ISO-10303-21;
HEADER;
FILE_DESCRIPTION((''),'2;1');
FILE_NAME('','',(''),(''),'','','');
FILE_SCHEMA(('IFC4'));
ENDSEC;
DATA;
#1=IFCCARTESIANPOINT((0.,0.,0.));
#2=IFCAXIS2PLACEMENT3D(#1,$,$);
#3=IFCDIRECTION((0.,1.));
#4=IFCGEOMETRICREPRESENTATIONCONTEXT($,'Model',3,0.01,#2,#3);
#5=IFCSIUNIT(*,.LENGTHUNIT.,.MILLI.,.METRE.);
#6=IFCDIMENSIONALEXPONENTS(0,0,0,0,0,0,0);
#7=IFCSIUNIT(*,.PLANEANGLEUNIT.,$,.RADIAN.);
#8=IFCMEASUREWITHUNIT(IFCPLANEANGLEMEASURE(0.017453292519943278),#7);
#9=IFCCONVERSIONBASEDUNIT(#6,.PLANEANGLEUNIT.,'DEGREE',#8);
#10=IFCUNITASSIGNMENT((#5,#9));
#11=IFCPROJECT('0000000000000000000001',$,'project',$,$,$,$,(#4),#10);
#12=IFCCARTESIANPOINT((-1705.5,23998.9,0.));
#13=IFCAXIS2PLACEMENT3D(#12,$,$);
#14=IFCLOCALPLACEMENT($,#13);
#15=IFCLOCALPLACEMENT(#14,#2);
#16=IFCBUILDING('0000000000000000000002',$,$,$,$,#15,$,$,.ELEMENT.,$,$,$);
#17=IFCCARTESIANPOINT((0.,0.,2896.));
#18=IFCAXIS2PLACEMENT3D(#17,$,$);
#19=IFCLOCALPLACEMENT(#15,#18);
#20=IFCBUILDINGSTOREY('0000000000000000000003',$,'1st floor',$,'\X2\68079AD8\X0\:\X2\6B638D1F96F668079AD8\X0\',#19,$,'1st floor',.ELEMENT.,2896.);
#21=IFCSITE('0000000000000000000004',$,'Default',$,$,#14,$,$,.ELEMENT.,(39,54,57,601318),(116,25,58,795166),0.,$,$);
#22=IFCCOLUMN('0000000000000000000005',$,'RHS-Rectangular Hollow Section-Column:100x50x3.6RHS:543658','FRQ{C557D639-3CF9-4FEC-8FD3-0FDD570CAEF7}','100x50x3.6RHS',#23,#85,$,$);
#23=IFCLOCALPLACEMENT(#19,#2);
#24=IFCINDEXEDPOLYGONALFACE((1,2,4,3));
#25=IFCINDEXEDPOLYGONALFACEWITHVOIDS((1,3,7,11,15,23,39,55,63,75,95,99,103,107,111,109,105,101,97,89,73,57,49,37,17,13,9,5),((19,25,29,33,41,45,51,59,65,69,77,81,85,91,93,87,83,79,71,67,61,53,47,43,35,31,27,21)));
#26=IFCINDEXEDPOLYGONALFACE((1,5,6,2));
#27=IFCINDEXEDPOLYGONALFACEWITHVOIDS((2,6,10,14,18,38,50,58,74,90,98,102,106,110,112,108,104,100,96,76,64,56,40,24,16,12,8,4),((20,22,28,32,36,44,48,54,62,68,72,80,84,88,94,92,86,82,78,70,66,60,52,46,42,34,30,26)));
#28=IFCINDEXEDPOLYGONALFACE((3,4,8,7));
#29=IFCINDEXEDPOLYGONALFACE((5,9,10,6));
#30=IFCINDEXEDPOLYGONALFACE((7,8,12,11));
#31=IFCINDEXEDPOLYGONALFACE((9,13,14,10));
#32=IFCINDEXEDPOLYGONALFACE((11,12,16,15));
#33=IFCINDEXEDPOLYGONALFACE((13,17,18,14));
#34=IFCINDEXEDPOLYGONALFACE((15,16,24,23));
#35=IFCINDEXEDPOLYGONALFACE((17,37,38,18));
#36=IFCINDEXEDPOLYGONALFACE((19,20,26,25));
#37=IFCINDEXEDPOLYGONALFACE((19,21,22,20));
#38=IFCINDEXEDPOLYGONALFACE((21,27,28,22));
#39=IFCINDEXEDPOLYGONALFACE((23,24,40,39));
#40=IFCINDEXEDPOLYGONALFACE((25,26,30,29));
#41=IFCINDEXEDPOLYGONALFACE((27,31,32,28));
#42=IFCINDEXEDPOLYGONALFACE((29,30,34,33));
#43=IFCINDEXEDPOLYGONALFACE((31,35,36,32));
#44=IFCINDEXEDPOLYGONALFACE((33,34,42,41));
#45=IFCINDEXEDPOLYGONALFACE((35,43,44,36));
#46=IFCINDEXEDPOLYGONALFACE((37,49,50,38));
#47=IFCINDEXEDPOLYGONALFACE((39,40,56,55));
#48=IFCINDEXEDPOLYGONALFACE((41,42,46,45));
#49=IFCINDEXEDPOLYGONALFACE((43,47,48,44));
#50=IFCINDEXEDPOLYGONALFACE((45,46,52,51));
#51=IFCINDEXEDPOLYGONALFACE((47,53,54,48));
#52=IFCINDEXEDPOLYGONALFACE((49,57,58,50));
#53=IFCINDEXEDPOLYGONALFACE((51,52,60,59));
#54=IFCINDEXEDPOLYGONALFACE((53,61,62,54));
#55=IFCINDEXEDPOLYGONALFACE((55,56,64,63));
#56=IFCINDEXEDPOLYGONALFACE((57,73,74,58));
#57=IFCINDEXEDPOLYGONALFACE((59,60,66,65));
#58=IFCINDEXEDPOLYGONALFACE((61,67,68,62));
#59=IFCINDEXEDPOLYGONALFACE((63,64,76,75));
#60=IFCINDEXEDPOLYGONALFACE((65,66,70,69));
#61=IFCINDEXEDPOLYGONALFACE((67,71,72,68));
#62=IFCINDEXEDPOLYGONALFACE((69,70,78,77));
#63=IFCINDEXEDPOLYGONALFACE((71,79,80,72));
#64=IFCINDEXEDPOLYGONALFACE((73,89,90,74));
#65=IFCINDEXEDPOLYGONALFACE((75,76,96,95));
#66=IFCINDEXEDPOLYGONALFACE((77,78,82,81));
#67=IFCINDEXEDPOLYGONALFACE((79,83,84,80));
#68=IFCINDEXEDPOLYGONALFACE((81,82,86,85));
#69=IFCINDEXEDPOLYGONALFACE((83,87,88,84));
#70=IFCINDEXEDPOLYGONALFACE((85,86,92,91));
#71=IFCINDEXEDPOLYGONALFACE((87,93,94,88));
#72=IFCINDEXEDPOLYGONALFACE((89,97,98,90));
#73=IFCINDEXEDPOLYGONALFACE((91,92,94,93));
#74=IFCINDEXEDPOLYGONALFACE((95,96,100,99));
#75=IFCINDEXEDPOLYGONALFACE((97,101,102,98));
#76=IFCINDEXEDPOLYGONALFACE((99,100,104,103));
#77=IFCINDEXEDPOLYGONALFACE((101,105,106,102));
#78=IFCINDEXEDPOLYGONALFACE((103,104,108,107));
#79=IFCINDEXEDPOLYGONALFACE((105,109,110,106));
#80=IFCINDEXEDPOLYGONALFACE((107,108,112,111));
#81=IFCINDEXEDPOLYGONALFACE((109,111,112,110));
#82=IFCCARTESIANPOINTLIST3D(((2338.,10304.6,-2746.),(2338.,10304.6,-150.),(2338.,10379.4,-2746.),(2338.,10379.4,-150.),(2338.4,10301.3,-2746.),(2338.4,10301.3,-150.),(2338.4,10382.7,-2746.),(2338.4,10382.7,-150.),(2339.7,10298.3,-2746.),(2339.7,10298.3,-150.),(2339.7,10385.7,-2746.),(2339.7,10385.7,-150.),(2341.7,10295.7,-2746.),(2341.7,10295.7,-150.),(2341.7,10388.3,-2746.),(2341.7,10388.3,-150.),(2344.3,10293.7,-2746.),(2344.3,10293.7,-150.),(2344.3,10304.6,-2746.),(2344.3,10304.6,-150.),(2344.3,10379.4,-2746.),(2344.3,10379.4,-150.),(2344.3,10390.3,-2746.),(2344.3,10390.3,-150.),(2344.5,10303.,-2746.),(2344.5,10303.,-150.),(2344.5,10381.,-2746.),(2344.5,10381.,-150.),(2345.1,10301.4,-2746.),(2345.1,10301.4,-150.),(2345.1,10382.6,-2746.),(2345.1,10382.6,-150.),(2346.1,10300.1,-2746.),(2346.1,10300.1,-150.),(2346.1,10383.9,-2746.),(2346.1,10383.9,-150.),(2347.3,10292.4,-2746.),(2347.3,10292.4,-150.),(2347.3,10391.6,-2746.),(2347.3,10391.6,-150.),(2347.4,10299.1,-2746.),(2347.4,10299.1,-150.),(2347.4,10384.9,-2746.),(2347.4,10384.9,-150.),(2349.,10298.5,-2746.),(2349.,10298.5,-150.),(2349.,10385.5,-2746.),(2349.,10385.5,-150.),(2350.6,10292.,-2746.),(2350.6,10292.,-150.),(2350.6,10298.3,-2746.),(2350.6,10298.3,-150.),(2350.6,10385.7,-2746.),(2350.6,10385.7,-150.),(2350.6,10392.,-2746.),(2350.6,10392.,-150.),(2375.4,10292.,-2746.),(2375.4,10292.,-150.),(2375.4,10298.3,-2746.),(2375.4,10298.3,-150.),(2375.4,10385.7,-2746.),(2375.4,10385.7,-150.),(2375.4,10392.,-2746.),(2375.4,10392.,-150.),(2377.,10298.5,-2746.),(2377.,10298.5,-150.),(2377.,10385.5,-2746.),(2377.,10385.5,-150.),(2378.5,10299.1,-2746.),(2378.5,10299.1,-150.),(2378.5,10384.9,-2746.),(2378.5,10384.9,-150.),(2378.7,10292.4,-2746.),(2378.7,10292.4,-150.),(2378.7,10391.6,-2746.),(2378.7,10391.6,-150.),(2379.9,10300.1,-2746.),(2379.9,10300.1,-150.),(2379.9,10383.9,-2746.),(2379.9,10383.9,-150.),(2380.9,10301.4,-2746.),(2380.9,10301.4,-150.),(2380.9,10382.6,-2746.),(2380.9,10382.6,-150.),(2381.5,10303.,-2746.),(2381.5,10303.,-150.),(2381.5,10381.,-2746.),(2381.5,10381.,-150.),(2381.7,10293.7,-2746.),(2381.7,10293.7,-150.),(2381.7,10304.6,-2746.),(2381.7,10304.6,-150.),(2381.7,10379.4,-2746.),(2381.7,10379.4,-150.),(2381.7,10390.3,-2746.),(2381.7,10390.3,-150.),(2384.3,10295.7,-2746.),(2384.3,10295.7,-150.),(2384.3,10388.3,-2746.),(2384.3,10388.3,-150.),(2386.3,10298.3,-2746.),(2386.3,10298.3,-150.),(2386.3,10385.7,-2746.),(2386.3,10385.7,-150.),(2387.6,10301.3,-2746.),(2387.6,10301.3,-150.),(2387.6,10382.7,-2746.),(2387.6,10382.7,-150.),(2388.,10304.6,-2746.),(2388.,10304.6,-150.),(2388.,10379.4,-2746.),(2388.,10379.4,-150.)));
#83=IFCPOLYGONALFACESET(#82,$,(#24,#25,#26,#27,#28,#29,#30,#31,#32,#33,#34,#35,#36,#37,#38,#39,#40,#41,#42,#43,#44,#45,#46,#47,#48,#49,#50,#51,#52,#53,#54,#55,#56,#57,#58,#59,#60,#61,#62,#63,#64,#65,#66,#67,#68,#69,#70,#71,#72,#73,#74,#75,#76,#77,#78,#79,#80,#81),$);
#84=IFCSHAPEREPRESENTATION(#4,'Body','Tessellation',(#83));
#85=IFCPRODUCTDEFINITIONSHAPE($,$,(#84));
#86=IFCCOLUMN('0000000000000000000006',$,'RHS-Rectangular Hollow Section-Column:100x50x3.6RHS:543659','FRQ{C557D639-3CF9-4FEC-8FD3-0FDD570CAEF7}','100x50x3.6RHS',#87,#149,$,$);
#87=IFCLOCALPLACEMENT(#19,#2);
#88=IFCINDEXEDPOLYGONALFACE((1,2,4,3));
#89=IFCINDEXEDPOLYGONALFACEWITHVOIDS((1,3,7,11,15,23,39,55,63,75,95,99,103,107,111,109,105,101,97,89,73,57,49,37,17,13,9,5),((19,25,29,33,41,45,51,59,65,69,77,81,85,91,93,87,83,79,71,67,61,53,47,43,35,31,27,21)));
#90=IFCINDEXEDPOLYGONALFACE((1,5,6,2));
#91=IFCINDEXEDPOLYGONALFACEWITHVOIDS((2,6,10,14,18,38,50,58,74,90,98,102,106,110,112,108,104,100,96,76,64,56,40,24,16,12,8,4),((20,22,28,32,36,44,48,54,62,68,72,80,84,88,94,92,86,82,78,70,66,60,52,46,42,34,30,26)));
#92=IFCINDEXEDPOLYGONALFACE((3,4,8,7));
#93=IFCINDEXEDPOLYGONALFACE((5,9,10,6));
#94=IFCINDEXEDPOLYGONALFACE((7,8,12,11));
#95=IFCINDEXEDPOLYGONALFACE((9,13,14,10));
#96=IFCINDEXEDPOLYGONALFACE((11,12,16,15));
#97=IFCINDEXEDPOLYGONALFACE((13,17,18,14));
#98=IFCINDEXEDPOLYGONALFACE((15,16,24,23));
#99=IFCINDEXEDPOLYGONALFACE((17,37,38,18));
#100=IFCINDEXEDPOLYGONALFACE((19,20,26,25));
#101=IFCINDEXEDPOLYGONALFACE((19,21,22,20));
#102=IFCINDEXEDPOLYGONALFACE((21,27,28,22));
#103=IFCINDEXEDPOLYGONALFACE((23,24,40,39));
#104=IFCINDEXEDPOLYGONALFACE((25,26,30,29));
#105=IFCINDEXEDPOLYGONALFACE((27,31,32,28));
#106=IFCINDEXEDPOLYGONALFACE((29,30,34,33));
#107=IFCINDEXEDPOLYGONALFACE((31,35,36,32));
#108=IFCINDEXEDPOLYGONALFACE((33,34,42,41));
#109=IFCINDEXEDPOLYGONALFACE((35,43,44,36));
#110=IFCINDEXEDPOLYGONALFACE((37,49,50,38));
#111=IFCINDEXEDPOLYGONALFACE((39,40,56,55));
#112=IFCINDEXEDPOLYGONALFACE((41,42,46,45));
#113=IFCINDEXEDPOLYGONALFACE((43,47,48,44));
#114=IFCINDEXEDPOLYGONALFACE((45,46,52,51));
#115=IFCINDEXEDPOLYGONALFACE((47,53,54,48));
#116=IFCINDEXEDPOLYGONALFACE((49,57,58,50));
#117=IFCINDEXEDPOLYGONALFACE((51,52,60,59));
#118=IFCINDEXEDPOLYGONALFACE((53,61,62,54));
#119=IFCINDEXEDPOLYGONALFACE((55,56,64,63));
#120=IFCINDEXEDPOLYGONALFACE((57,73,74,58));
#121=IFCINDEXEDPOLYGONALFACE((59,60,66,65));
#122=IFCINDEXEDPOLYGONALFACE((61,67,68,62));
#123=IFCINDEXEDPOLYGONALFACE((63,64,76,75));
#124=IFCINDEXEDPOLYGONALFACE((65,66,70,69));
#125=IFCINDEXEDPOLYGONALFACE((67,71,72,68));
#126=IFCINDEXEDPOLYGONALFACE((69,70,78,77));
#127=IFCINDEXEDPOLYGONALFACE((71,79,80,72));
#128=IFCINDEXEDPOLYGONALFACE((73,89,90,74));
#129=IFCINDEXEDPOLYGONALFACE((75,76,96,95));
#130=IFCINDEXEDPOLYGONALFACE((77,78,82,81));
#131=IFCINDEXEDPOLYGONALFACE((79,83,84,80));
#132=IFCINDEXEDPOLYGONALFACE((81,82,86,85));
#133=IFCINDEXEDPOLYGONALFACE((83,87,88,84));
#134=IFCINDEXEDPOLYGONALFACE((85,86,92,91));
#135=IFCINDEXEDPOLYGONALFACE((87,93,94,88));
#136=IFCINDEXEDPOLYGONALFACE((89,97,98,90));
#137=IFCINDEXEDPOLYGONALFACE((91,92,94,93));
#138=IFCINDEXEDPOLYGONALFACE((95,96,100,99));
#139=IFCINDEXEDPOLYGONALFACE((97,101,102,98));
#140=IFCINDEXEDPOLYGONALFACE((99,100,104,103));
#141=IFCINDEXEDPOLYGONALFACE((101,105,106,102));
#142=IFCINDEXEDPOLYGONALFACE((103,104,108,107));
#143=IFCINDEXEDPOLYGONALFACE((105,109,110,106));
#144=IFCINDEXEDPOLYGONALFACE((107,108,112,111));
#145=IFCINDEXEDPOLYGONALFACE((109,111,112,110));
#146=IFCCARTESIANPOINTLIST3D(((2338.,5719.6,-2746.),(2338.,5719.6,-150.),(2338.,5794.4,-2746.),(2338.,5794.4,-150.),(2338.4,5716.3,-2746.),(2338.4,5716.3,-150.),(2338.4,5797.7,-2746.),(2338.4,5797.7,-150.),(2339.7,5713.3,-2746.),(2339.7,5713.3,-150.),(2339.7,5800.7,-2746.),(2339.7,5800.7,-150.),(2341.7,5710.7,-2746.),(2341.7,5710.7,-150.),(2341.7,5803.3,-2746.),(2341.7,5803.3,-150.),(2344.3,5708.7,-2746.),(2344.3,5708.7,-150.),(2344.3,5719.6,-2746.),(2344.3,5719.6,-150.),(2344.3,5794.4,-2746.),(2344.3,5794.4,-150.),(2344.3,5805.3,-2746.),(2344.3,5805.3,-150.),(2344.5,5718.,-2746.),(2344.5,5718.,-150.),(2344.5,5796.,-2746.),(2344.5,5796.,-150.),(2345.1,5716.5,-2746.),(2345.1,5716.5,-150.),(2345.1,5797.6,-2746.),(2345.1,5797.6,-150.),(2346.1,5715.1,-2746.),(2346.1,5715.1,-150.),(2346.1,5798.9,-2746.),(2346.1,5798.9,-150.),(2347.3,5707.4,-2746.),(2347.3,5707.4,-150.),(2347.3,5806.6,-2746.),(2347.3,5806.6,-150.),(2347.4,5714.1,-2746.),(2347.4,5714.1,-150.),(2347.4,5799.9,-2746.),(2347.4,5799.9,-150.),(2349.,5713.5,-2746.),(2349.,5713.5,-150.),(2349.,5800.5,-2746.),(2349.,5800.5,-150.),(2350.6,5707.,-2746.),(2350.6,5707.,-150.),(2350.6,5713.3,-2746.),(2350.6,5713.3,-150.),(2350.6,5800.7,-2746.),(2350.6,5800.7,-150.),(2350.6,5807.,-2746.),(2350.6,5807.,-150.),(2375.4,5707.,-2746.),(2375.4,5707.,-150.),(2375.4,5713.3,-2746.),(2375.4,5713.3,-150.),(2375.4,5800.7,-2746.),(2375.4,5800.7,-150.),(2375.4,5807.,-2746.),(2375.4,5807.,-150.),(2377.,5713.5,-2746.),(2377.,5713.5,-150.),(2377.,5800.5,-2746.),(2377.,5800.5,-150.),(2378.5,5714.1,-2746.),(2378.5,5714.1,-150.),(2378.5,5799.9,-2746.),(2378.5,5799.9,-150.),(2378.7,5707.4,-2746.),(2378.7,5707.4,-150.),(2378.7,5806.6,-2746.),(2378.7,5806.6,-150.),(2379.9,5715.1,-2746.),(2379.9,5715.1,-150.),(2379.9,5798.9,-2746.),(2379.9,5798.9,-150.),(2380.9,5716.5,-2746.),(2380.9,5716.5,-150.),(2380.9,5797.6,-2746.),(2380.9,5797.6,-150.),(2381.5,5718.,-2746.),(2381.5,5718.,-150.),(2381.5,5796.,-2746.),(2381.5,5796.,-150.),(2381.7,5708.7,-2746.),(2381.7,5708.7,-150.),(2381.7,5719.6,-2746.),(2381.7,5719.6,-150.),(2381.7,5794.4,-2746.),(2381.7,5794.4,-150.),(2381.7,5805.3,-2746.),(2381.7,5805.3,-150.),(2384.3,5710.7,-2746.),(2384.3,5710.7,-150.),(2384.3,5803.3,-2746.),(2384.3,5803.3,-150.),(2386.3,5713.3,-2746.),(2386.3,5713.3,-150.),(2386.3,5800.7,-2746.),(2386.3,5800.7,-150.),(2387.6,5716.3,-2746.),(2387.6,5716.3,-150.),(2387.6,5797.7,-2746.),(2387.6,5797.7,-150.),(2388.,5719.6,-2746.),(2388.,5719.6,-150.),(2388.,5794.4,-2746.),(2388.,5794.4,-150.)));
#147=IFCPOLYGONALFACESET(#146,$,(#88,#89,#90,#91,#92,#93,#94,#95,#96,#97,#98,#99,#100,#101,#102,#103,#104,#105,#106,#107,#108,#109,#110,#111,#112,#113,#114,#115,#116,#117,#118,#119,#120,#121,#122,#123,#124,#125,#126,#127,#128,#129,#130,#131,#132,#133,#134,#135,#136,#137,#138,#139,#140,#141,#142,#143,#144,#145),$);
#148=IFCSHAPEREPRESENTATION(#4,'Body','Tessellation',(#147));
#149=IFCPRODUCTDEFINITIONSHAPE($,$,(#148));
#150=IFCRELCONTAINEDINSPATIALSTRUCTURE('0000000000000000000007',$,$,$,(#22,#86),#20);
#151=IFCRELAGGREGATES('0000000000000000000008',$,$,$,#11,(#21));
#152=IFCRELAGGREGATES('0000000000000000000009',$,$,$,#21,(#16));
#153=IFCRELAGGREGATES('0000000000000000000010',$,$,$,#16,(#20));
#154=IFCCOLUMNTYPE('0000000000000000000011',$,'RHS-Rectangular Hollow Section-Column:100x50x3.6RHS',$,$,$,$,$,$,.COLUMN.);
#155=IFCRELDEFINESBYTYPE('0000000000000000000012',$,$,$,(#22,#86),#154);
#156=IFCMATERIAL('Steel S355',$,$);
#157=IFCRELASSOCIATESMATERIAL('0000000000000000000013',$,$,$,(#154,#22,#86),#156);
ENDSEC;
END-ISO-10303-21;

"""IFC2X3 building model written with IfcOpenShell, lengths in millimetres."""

from ifc_helpers import new_model, entity, si_unit, converted_unit, direction, frame, origin, origin_2d, place, context, project, spatial, hollow_rectangle, extrude, clip, halfspace, material, type_object, element, save


model = new_model("IFC2X3")

# Units and contexts
model_context = context("Model", 3, precision=0.01, world=origin(), true_north=direction((0.0, 1.0)))
ifc_project = project(units=[si_unit("LENGTHUNIT", "METRE", prefix="MILLI"), converted_unit("PLANEANGLEUNIT", "DEGREE", entity("IfcPlaneAngleMeasure", 0.017453292519943278), si_unit("PLANEANGLEUNIT", "RADIAN"), dimensions=[0, 0, 0, 0, 0, 0, 0])], contexts=[model_context])

# Site, building, storey
site_placement = place(None, frame((-1705.5, 23998.9, 0.0)))
site = spatial("IfcSite", under=ifc_project, at=site_placement, Name="Default", CompositionType="ELEMENT", RefLatitude=(39, 54, 57, 601318), RefLongitude=(116, 25, 58, 795166), RefElevation=0.0)
building_placement = place(site_placement, origin())
building = spatial("IfcBuilding", under=site, at=building_placement, CompositionType="ELEMENT")
storey_placement = place(building_placement, frame((0.0, 0.0, 2896.0)))
storey = spatial("IfcBuildingStorey", under=building, at=storey_placement, Name="1st floor", ObjectType="标高:正负零标高", LongName="1st floor", CompositionType="ELEMENT", Elevation=2896.0)

# Columns
ifc_material_1 = material(Name="Steel S355")
column_type = type_object("IfcColumnType", Name="RHS-Rectangular Hollow Section-Column:100x50x3.6RHS", PredefinedType="COLUMN", material=ifc_material_1)
column_1_placement = place(storey_placement, frame((2363.0, 10342.0, -150.0), z_axis=(0.0, 0.0, 1.0), x_axis=(-1.0, 0.0, 0.0)))
element("IfcColumn", 1, at=column_1_placement, inside=storey, type_object=column_type, material=ifc_material_1, Name="RHS-Rectangular Hollow Section-Column:100x50x3.6RHS:543658", Description="FRQ{C557D639-3CF9-4FEC-8FD3-0FDD570CAEF7}", ObjectType="100x50x3.6RHS", context=model_context, shape_type="Clipping", body=[
    clip(extrude(hollow_rectangle(XDim=50.0, YDim=100.0, WallThickness=6.3, InnerFilletRadius=6.3, OuterFilletRadius=12.6, at=origin_2d()), origin(), (0.0, 0.0, -1.0), 2651.9), halfspace(frame((2363.0, 10342.0, -2596.0), z_axis=(0.0, 0.0, 1.0), x_axis=(-1.0, 0.0, 0.0)), True)),
])
column_2_placement = place(storey_placement, frame((2363.0, 5757.0, -150.0), z_axis=(0.0, 0.0, 1.0), x_axis=(-1.0, 0.0, 0.0)))
element("IfcColumn", 2, at=column_2_placement, inside=storey, type_object=column_type, material=ifc_material_1, Name="RHS-Rectangular Hollow Section-Column:100x50x3.6RHS:543659", Description="FRQ{C557D639-3CF9-4FEC-8FD3-0FDD570CAEF7}", ObjectType="100x50x3.6RHS", context=model_context, shape_type="Clipping", body=[
    clip(extrude(hollow_rectangle(XDim=50.0, YDim=100.0, WallThickness=6.3, InnerFilletRadius=6.3, OuterFilletRadius=12.6, at=origin_2d()), origin(), (0.0, 0.0, -1.0), 2651.9), halfspace(frame((2363.0, 5757.0, -2596.0), z_axis=(0.0, 0.0, 1.0), x_axis=(-1.0, 0.0, 0.0)), True)),
])

save(model, "model.ifc")
